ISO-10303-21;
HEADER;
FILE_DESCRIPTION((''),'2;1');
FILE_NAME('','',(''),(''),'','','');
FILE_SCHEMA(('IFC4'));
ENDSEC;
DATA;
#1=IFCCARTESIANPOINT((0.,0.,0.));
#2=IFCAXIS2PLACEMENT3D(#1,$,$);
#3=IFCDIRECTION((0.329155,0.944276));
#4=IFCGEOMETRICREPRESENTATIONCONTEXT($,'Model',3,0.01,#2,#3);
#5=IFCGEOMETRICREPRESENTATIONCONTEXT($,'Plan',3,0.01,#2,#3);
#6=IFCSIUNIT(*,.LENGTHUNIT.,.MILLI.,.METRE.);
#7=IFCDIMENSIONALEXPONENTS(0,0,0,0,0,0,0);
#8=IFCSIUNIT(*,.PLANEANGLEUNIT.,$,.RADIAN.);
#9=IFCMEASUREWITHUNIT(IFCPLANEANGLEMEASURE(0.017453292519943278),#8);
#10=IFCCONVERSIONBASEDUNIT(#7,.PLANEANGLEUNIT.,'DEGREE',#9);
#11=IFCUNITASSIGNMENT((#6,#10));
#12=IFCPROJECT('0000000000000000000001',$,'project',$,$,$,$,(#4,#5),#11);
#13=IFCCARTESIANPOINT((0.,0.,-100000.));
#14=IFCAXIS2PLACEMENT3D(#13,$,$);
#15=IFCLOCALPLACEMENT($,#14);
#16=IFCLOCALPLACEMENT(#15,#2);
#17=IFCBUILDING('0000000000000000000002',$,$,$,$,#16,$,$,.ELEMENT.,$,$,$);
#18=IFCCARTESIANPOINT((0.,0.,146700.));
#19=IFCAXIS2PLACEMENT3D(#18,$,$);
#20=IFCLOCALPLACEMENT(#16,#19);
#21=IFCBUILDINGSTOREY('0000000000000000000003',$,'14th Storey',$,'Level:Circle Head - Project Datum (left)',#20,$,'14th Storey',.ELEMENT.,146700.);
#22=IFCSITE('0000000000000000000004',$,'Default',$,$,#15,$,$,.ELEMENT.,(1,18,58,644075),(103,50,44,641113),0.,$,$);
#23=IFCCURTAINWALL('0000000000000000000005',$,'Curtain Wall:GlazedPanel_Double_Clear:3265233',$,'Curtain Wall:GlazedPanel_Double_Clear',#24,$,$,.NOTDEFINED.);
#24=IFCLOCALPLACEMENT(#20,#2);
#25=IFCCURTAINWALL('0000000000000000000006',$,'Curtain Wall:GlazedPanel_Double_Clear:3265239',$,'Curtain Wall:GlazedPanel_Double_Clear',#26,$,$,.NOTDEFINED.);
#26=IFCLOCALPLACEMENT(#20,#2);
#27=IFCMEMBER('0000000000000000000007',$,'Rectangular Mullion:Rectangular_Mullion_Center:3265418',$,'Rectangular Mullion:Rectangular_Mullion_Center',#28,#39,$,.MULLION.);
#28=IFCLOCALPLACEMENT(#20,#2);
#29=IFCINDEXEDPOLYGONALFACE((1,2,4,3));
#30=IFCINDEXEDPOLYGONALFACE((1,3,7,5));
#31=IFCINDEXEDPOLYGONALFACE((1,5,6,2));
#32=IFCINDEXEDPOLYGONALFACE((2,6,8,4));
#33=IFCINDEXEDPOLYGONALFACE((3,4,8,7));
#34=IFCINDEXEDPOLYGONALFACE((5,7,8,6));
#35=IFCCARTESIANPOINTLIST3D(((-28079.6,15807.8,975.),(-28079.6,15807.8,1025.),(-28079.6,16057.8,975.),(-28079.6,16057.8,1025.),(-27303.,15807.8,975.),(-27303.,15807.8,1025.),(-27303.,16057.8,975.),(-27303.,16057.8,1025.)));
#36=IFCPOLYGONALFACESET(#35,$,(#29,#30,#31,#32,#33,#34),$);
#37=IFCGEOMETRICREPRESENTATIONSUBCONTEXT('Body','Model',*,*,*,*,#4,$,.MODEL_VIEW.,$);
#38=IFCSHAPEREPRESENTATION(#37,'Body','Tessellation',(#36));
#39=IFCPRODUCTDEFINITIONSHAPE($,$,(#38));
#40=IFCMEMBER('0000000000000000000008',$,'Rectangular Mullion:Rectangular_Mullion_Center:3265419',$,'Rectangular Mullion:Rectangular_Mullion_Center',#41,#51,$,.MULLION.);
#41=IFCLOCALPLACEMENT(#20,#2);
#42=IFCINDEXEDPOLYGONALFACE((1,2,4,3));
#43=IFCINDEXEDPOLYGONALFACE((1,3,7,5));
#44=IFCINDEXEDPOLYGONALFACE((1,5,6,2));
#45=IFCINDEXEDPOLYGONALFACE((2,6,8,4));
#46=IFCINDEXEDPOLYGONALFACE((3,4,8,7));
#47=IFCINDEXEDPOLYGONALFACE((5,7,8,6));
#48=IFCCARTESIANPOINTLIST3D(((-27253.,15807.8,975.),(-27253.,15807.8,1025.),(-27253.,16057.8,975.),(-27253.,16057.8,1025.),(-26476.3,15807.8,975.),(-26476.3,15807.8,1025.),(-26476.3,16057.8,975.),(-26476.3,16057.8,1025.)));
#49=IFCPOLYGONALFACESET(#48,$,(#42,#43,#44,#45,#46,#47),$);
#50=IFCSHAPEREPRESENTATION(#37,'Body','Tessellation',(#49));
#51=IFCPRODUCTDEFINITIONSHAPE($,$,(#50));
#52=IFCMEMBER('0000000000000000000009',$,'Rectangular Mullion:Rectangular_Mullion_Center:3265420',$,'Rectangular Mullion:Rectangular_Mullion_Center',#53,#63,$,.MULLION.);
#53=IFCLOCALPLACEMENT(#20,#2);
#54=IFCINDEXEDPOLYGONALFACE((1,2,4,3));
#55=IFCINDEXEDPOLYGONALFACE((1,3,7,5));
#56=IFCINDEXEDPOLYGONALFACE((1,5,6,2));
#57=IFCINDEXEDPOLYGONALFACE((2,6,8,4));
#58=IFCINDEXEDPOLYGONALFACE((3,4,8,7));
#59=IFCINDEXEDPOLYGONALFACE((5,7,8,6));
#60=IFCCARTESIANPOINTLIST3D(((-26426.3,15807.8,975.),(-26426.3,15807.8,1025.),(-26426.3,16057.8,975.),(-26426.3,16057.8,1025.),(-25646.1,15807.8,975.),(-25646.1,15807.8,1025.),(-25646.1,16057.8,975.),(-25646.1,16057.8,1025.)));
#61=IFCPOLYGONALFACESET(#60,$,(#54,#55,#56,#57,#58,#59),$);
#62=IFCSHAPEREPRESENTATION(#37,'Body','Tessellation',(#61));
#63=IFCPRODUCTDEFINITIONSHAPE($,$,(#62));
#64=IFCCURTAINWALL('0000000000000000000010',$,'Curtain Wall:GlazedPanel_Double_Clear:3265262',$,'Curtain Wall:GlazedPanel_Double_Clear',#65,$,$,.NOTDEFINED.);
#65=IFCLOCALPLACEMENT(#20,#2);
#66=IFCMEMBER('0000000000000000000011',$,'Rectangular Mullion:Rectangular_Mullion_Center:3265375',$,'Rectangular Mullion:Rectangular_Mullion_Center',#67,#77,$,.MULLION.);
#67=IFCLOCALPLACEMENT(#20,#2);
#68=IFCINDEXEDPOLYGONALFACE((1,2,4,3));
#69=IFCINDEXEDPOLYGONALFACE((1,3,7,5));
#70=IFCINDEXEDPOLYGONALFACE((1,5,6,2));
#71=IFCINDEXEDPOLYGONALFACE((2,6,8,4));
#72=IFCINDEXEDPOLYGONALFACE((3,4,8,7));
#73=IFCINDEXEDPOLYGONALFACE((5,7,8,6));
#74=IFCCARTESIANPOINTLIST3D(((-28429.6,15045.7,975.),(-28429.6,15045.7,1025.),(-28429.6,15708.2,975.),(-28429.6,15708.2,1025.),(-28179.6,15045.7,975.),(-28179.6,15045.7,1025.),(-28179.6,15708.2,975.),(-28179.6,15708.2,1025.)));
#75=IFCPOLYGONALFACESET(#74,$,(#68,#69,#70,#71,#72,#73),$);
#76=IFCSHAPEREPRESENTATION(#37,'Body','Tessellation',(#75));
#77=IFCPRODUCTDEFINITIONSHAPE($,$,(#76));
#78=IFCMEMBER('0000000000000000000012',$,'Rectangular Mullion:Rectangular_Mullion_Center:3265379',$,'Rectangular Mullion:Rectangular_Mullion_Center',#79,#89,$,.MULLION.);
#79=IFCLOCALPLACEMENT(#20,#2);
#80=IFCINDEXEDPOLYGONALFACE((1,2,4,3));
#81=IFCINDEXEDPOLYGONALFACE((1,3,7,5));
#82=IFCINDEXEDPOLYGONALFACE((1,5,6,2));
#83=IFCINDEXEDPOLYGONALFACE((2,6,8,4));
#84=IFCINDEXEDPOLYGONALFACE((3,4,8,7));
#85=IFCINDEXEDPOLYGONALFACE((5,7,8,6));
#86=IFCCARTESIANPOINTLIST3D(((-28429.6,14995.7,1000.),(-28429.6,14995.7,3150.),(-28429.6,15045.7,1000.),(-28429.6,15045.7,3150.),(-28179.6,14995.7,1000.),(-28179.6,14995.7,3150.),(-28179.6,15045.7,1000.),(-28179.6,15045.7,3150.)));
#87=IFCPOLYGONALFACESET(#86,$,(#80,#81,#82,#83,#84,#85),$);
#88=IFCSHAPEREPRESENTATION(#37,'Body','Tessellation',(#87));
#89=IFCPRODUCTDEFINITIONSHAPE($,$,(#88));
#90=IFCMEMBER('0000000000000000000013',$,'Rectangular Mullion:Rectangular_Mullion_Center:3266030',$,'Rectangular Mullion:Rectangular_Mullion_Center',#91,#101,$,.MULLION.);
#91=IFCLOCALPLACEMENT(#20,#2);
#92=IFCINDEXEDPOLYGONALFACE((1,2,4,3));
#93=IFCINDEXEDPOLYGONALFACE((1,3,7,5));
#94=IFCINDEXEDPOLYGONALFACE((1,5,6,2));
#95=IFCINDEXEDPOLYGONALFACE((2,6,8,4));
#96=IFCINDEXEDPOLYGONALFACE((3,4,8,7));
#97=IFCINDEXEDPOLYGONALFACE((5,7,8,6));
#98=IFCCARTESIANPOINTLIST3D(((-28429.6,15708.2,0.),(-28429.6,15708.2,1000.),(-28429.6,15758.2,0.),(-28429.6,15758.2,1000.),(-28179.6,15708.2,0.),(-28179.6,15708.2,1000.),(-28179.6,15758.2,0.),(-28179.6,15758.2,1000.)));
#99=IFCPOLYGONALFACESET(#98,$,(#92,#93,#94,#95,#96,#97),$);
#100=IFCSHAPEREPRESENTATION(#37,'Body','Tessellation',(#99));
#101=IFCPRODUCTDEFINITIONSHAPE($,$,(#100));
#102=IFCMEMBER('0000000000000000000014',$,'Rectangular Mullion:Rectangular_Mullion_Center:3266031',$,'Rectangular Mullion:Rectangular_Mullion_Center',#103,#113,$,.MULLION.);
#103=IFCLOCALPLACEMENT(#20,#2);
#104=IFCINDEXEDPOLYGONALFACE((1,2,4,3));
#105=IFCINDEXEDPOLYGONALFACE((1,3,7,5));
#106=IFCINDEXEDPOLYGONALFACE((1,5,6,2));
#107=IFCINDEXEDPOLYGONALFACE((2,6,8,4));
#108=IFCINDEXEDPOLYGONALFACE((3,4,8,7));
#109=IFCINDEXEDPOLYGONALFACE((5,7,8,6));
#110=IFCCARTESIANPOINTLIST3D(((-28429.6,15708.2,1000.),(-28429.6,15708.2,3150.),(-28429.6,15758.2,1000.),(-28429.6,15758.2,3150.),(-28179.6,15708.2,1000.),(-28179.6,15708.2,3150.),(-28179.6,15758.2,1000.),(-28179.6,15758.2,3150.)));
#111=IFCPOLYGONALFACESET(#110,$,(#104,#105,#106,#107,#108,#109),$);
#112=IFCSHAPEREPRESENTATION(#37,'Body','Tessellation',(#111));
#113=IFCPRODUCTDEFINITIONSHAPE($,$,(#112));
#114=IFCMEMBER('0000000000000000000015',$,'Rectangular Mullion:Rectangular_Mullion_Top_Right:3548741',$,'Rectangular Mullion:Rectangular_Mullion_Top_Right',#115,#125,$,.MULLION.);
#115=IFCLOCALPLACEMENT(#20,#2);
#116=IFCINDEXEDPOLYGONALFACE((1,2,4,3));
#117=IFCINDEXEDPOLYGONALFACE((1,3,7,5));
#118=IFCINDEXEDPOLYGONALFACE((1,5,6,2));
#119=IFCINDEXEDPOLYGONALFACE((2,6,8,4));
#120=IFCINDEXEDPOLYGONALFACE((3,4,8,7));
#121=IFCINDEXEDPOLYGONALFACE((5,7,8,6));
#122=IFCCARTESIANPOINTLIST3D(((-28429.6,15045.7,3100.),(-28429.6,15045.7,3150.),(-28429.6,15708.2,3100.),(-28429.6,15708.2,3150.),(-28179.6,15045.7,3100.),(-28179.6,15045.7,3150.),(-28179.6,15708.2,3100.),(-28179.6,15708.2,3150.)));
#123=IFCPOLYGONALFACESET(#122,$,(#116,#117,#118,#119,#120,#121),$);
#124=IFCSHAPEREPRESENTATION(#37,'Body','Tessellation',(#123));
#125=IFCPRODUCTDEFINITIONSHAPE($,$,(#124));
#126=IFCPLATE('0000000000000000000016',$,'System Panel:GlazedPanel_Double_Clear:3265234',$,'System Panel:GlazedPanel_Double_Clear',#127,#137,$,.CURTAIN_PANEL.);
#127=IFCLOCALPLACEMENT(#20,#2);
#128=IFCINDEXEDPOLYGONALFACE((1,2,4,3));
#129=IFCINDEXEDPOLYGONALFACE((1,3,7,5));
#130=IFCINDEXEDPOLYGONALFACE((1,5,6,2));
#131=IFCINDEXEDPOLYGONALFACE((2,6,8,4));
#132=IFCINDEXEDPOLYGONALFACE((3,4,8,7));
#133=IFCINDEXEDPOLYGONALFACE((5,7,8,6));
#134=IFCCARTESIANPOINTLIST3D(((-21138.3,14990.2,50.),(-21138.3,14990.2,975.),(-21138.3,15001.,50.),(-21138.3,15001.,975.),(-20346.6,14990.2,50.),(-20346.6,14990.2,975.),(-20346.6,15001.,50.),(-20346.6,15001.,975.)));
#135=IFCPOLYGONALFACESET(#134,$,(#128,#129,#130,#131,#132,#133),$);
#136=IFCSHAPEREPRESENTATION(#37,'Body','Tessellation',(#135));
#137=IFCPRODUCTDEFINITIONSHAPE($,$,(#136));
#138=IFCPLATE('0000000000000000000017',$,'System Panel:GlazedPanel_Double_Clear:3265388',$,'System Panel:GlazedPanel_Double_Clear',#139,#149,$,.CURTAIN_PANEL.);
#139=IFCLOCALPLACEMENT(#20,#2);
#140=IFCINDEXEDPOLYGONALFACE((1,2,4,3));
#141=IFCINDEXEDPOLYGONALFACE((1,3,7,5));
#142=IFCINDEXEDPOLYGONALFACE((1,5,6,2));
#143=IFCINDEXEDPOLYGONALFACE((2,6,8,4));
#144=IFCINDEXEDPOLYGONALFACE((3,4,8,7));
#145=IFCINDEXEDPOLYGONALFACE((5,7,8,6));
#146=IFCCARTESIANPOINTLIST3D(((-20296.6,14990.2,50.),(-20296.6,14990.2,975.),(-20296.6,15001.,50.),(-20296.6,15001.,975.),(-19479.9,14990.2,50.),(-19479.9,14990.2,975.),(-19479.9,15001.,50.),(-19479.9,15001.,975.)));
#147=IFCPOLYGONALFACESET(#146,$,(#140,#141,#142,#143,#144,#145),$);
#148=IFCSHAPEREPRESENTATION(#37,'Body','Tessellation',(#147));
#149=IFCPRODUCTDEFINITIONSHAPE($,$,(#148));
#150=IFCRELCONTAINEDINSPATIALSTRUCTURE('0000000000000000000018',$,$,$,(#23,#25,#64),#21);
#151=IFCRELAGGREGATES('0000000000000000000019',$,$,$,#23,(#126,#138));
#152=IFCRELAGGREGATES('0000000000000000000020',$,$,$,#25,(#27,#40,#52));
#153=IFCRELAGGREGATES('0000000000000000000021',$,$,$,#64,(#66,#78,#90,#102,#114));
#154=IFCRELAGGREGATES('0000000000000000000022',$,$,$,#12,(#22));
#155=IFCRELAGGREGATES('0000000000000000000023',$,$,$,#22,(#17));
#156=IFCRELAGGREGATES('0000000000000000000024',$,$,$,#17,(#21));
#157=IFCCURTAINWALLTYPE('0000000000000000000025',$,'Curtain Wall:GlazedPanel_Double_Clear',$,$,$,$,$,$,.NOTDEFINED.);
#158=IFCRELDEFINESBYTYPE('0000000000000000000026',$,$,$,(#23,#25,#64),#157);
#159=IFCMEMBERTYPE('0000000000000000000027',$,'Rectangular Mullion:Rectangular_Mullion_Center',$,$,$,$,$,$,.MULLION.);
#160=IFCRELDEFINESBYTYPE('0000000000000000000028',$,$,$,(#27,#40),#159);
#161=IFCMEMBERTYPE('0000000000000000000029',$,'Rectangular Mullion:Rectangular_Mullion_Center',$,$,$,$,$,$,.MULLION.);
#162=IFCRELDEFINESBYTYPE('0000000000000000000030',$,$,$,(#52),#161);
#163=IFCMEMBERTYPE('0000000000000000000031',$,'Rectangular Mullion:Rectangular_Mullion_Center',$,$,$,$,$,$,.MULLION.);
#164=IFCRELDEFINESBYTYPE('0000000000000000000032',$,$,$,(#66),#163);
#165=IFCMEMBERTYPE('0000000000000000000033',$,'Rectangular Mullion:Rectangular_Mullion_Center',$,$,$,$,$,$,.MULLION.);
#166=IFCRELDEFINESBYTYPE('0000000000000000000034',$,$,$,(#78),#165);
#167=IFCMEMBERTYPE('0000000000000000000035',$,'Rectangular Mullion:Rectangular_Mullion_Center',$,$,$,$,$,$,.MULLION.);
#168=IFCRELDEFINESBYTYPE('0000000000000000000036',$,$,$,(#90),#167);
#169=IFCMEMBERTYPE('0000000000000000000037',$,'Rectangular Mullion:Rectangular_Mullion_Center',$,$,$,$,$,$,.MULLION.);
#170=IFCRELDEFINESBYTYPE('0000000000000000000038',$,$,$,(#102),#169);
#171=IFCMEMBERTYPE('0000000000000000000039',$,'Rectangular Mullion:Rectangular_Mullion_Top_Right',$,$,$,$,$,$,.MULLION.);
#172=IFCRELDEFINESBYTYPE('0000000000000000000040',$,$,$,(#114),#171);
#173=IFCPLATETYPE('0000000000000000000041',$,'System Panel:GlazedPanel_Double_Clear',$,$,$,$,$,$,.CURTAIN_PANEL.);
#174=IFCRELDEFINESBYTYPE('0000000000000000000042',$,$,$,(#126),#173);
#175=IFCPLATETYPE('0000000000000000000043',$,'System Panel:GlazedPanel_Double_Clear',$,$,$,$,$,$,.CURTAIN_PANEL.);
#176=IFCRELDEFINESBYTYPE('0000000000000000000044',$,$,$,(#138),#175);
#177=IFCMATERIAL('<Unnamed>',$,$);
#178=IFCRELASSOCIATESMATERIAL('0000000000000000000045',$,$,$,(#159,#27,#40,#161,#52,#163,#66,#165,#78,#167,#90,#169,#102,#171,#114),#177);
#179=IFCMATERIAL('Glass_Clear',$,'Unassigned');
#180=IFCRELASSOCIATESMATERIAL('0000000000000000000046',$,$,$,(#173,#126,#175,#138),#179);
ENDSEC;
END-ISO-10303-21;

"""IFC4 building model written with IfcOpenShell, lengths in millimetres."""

from ifc_helpers import new_model, entity, si_unit, converted_unit, direction, frame, origin, place, context, subcontext, project, spatial, indexed_curve, outline, extrude, source, transform, mapped, material, type_object, type_shapes, element, aggregate, save


model = new_model("IFC4")

# Units and contexts
model_context = context("Model", 3, precision=0.01, world=origin(), true_north=direction((0.329155, 0.944276)))
plan_context = context("Plan", 3, precision=0.01, world=origin(), true_north=direction((0.329155, 0.944276)))
body_context = subcontext(model_context, "Body", "Model", "MODEL_VIEW")
ifc_project = project(units=[si_unit("LENGTHUNIT", "METRE", prefix="MILLI"), converted_unit("PLANEANGLEUNIT", "DEGREE", entity("IfcPlaneAngleMeasure", 0.017453292519943278), si_unit("PLANEANGLEUNIT", "RADIAN"), dimensions=[0, 0, 0, 0, 0, 0, 0])], contexts=[model_context, plan_context])

# Site, building, storey
site_placement = place(None, frame((0.0, 0.0, -100000.0)))
site = spatial("IfcSite", under=ifc_project, at=site_placement, Name="Default", CompositionType="ELEMENT", RefLatitude=(1, 18, 58, 644075), RefLongitude=(103, 50, 44, 641113), RefElevation=0.0)
building_placement = place(site_placement, origin())
building = spatial("IfcBuilding", under=site, at=building_placement, CompositionType="ELEMENT")
storey_placement = place(building_placement, frame((0.0, 0.0, 146700.0)))
storey = spatial("IfcBuildingStorey", under=building, at=storey_placement, Name="14th Storey", ObjectType="Level:Circle Head - Project Datum (left)", LongName="14th Storey", CompositionType="ELEMENT", Elevation=146700.0)

# Curtain wall
curtain_wall_type = type_object("IfcCurtainWallType", Name="Curtain Wall:GlazedPanel_Double_Clear", PredefinedType="NOTDEFINED")
curtain_wall_1_placement = place(storey_placement, frame((0.0, 0.0, -146700.0)))
curtain_wall_1 = element("IfcCurtainWall", 1, at=curtain_wall_1_placement, inside=storey, type_object=curtain_wall_type, Name="Curtain Wall:GlazedPanel_Double_Clear:3265233", ObjectType="Curtain Wall:GlazedPanel_Double_Clear", PredefinedType="NOTDEFINED")
ifc_material_1 = material(Name="<Unnamed>")

# Curtain wall
curtain_wall_2_placement = place(storey_placement, frame((0.0, 0.0, -146700.0)))
curtain_wall_2 = element("IfcCurtainWall", 2, at=curtain_wall_2_placement, inside=storey, type_object=curtain_wall_type, Name="Curtain Wall:GlazedPanel_Double_Clear:3265239", ObjectType="Curtain Wall:GlazedPanel_Double_Clear", PredefinedType="NOTDEFINED")

# Members
member_type_1 = type_object("IfcMemberType", Name="Rectangular Mullion:Rectangular_Mullion_Center", PredefinedType="MULLION", material=ifc_material_1)
shared_shape_1 = source(origin(), body_context, "Body", "SweptSolid", [
    extrude(outline(indexed_curve([(-25.0, -125.0), (25.0, -125.0), (25.0, 125.0), (-25.0, 125.0), (-25.0, -125.0)], self_intersect=False)), frame((0.0, 0.0, -776.7), z_axis=(0.0, 0.0, 1.0), x_axis=(-1.0, 0.0, 0.0)), (0.0, 0.0, 1.0), 776.7),
])
type_shapes(member_type_1, [shared_shape_1])
member_1_placement = place(curtain_wall_2_placement, frame((-27303.0, 15932.8, 147700.0), z_axis=(1.0, 0.0, 0.0), x_axis=(0.0, 0.0, 1.0)))
member_1 = element("IfcMember", 3, at=member_1_placement, type_object=member_type_1, material=ifc_material_1, Name="Rectangular Mullion:Rectangular_Mullion_Center:3265418", ObjectType="Rectangular Mullion:Rectangular_Mullion_Center", PredefinedType="MULLION", context=body_context, shape_type="MappedRepresentation", body=[
    mapped(shared_shape_1, transform((0.0, 0.0, 0.0), scale=1.0)),
])
member_2_placement = place(curtain_wall_2_placement, frame((-26476.3, 15932.8, 147700.0), z_axis=(1.0, 0.0, 0.0), x_axis=(0.0, 0.0, 1.0)))
member_2 = element("IfcMember", 4, at=member_2_placement, type_object=member_type_1, material=ifc_material_1, Name="Rectangular Mullion:Rectangular_Mullion_Center:3265419", ObjectType="Rectangular Mullion:Rectangular_Mullion_Center", PredefinedType="MULLION", context=body_context, shape_type="MappedRepresentation", body=[
    mapped(shared_shape_1, transform((0.0, 0.0, 0.0), scale=1.0)),
])
member_type_2 = type_object("IfcMemberType", Name="Rectangular Mullion:Rectangular_Mullion_Center", PredefinedType="MULLION", material=ifc_material_1)
shared_shape_2 = source(origin(), body_context, "Body", "SweptSolid", [
    extrude(outline(indexed_curve([(-25.0, -125.0), (25.0, -125.0), (25.0, 125.0), (-25.0, 125.0), (-25.0, -125.0)], self_intersect=False)), frame((0.0, 0.0, -780.2), z_axis=(0.0, 0.0, 1.0), x_axis=(-1.0, 0.0, 0.0)), (0.0, 0.0, 1.0), 780.2),
])
type_shapes(member_type_2, [shared_shape_2])
member_3_placement = place(curtain_wall_2_placement, frame((-25646.1, 15932.8, 147700.0), z_axis=(1.0, 0.0, 0.0), x_axis=(0.0, 0.0, 1.0)))
member_3 = element("IfcMember", 5, at=member_3_placement, type_object=member_type_2, material=ifc_material_1, Name="Rectangular Mullion:Rectangular_Mullion_Center:3265420", ObjectType="Rectangular Mullion:Rectangular_Mullion_Center", PredefinedType="MULLION", context=body_context, shape_type="MappedRepresentation", body=[
    mapped(shared_shape_2, transform((0.0, 0.0, 0.0), scale=1.0)),
])

# Curtain wall, members
curtain_wall_3_placement = place(storey_placement, frame((0.0, 0.0, -146700.0)))
curtain_wall_3 = element("IfcCurtainWall", 6, at=curtain_wall_3_placement, inside=storey, type_object=curtain_wall_type, Name="Curtain Wall:GlazedPanel_Double_Clear:3265262", ObjectType="Curtain Wall:GlazedPanel_Double_Clear", PredefinedType="NOTDEFINED")
member_type_3 = type_object("IfcMemberType", Name="Rectangular Mullion:Rectangular_Mullion_Center", PredefinedType="MULLION", material=ifc_material_1)
shared_shape_3 = source(origin(), body_context, "Body", "SweptSolid", [
    extrude(outline(indexed_curve([(-25.0, -125.0), (25.0, -125.0), (25.0, 125.0), (-25.0, 125.0), (-25.0, -125.0)], self_intersect=False)), frame((0.0, 0.0, -662.5), z_axis=(0.0, 0.0, 1.0), x_axis=(-1.0, 0.0, 0.0)), (0.0, 0.0, 1.0), 662.5),
])
type_shapes(member_type_3, [shared_shape_3])
member_4_placement = place(curtain_wall_3_placement, frame((-28304.6, 15045.7, 147700.0), z_axis=(0.0, -1.0, 0.0), x_axis=(0.0, 0.0, 1.0)))
member_4 = element("IfcMember", 7, at=member_4_placement, type_object=member_type_3, material=ifc_material_1, Name="Rectangular Mullion:Rectangular_Mullion_Center:3265375", ObjectType="Rectangular Mullion:Rectangular_Mullion_Center", PredefinedType="MULLION", context=body_context, shape_type="MappedRepresentation", body=[
    mapped(shared_shape_3, transform((0.0, 0.0, 0.0), scale=1.0)),
])
member_type_4 = type_object("IfcMemberType", Name="Rectangular Mullion:Rectangular_Mullion_Center", PredefinedType="MULLION", material=ifc_material_1)
shared_shape_4 = source(origin(), body_context, "Body", "SweptSolid", [
    extrude(outline(indexed_curve([(-25.0, -125.0), (25.0, -125.0), (25.0, 125.0), (-25.0, 125.0), (-25.0, -125.0)], self_intersect=False)), frame((0.0, 0.0, -2150.0), z_axis=(0.0, 0.0, 1.0), x_axis=(-1.0, 0.0, 0.0)), (0.0, 0.0, 1.0), 2150.0),
])
type_shapes(member_type_4, [shared_shape_4])
member_5_placement = place(curtain_wall_3_placement, frame((-28304.6, 15020.7, 147700.0), z_axis=(0.0, 0.0, -1.0), x_axis=(0.0, -1.0, 0.0)))
member_5 = element("IfcMember", 8, at=member_5_placement, type_object=member_type_4, material=ifc_material_1, Name="Rectangular Mullion:Rectangular_Mullion_Center:3265379", ObjectType="Rectangular Mullion:Rectangular_Mullion_Center", PredefinedType="MULLION", context=body_context, shape_type="MappedRepresentation", body=[
    mapped(shared_shape_4, transform((0.0, 0.0, 0.0), scale=1.0)),
])
member_type_5 = type_object("IfcMemberType", Name="Rectangular Mullion:Rectangular_Mullion_Center", PredefinedType="MULLION", material=ifc_material_1)
shared_shape_5 = source(origin(), body_context, "Body", "SweptSolid", [
    extrude(outline(indexed_curve([(-25.0, -125.0), (25.0, -125.0), (25.0, 125.0), (-25.0, 125.0), (-25.0, -125.0)], self_intersect=False)), frame((-25.0, 0.0, -1000.0), z_axis=(0.0, 0.0, 1.0), x_axis=(-1.0, 0.0, 0.0)), (0.0, 0.0, 1.0), 1000.0),
])
type_shapes(member_type_5, [shared_shape_5])
member_6_placement = place(curtain_wall_3_placement, frame((-28304.6, 15758.2, 147700.0), z_axis=(0.0, 0.0, 1.0), x_axis=(0.0, 1.0, 0.0)))
member_6 = element("IfcMember", 9, at=member_6_placement, type_object=member_type_5, material=ifc_material_1, Name="Rectangular Mullion:Rectangular_Mullion_Center:3266030", ObjectType="Rectangular Mullion:Rectangular_Mullion_Center", PredefinedType="MULLION", context=body_context, shape_type="MappedRepresentation", body=[
    mapped(shared_shape_5, transform((0.0, 0.0, 0.0), scale=1.0)),
])
member_type_6 = type_object("IfcMemberType", Name="Rectangular Mullion:Rectangular_Mullion_Center", PredefinedType="MULLION", material=ifc_material_1)
shared_shape_6 = source(origin(), body_context, "Body", "SweptSolid", [
    extrude(outline(indexed_curve([(-25.0, -125.0), (25.0, -125.0), (25.0, 125.0), (-25.0, 125.0), (-25.0, -125.0)], self_intersect=False)), frame((-25.0, 0.0, -2150.0), z_axis=(0.0, 0.0, 1.0), x_axis=(-1.0, 0.0, 0.0)), (0.0, 0.0, 1.0), 2150.0),
])
type_shapes(member_type_6, [shared_shape_6])
member_7_placement = place(curtain_wall_3_placement, frame((-28304.6, 15758.2, 149850.0), z_axis=(0.0, 0.0, 1.0), x_axis=(0.0, 1.0, 0.0)))
member_7 = element("IfcMember", 10, at=member_7_placement, type_object=member_type_6, material=ifc_material_1, Name="Rectangular Mullion:Rectangular_Mullion_Center:3266031", ObjectType="Rectangular Mullion:Rectangular_Mullion_Center", PredefinedType="MULLION", context=body_context, shape_type="MappedRepresentation", body=[
    mapped(shared_shape_6, transform((0.0, 0.0, 0.0), scale=1.0)),
])
member_type_7 = type_object("IfcMemberType", Name="Rectangular Mullion:Rectangular_Mullion_Top_Right", PredefinedType="MULLION", material=ifc_material_1)
shared_shape_7 = source(origin(), body_context, "Body", "SweptSolid", [
    extrude(outline(indexed_curve([(-25.0, -125.0), (25.0, -125.0), (25.0, 125.0), (-25.0, 125.0), (-25.0, -125.0)], self_intersect=False)), frame((-25.0, 0.0, -662.5), z_axis=(0.0, 0.0, 1.0), x_axis=(-1.0, 0.0, 0.0)), (0.0, 0.0, 1.0), 662.5),
])
type_shapes(member_type_7, [shared_shape_7])
member_8_placement = place(curtain_wall_3_placement, frame((-28304.6, 15045.7, 149850.0), z_axis=(0.0, -1.0, 0.0), x_axis=(0.0, 0.0, 1.0)))
member_8 = element("IfcMember", 11, at=member_8_placement, type_object=member_type_7, material=ifc_material_1, Name="Rectangular Mullion:Rectangular_Mullion_Top_Right:3548741", ObjectType="Rectangular Mullion:Rectangular_Mullion_Top_Right", PredefinedType="MULLION", context=body_context, shape_type="MappedRepresentation", body=[
    mapped(shared_shape_7, transform((0.0, 0.0, 0.0), scale=1.0)),
])

# Plates
ifc_material_2 = material(Name="Glass_Clear", Category="Unassigned")
plate_type_1 = type_object("IfcPlateType", Name="System Panel:GlazedPanel_Double_Clear", PredefinedType="CURTAIN_PANEL", material=ifc_material_2)
shared_shape_8 = source(origin(), body_context, "Body", "SweptSolid", [
    extrude(outline(indexed_curve([(-5.4, -395.8), (5.4, -395.8), (5.4, 395.8), (-5.4, 395.8), (-5.4, -395.8)], self_intersect=False)), frame((395.8, 5.4, 0.0), z_axis=(0.0, 0.0, 1.0), x_axis=(0.0, 1.0, 0.0)), (0.0, 0.0, 1.0), 925.0),
])
type_shapes(plate_type_1, [shared_shape_8])
plate_1_placement = place(curtain_wall_1_placement, frame((-21138.3, 14990.2, 146750.0)))
plate_1 = element("IfcPlate", 12, at=plate_1_placement, type_object=plate_type_1, material=ifc_material_2, Name="System Panel:GlazedPanel_Double_Clear:3265234", ObjectType="System Panel:GlazedPanel_Double_Clear", PredefinedType="CURTAIN_PANEL", context=body_context, shape_type="MappedRepresentation", body=[
    mapped(shared_shape_8, transform((0.0, 0.0, 0.0), scale=1.0)),
])
plate_type_2 = type_object("IfcPlateType", Name="System Panel:GlazedPanel_Double_Clear", PredefinedType="CURTAIN_PANEL", material=ifc_material_2)
shared_shape_9 = source(origin(), body_context, "Body", "SweptSolid", [
    extrude(outline(indexed_curve([(-5.4, -408.3), (5.4, -408.3), (5.4, 408.3), (-5.4, 408.3), (-5.4, -408.3)], self_intersect=False)), frame((408.3, 5.4, 0.0), z_axis=(0.0, 0.0, 1.0), x_axis=(0.0, 1.0, 0.0)), (0.0, 0.0, 1.0), 925.0),
])
type_shapes(plate_type_2, [shared_shape_9])
plate_2_placement = place(curtain_wall_1_placement, frame((-20296.6, 14990.2, 146750.0)))
plate_2 = element("IfcPlate", 13, at=plate_2_placement, type_object=plate_type_2, material=ifc_material_2, Name="System Panel:GlazedPanel_Double_Clear:3265388", ObjectType="System Panel:GlazedPanel_Double_Clear", PredefinedType="CURTAIN_PANEL", context=body_context, shape_type="MappedRepresentation", body=[
    mapped(shared_shape_9, transform((0.0, 0.0, 0.0), scale=1.0)),
])
aggregate(curtain_wall_1, [plate_1, plate_2])
aggregate(curtain_wall_2, [member_1, member_2, member_3])
aggregate(curtain_wall_3, [member_4, member_5, member_6, member_7, member_8])

save(model, "model.ifc")
